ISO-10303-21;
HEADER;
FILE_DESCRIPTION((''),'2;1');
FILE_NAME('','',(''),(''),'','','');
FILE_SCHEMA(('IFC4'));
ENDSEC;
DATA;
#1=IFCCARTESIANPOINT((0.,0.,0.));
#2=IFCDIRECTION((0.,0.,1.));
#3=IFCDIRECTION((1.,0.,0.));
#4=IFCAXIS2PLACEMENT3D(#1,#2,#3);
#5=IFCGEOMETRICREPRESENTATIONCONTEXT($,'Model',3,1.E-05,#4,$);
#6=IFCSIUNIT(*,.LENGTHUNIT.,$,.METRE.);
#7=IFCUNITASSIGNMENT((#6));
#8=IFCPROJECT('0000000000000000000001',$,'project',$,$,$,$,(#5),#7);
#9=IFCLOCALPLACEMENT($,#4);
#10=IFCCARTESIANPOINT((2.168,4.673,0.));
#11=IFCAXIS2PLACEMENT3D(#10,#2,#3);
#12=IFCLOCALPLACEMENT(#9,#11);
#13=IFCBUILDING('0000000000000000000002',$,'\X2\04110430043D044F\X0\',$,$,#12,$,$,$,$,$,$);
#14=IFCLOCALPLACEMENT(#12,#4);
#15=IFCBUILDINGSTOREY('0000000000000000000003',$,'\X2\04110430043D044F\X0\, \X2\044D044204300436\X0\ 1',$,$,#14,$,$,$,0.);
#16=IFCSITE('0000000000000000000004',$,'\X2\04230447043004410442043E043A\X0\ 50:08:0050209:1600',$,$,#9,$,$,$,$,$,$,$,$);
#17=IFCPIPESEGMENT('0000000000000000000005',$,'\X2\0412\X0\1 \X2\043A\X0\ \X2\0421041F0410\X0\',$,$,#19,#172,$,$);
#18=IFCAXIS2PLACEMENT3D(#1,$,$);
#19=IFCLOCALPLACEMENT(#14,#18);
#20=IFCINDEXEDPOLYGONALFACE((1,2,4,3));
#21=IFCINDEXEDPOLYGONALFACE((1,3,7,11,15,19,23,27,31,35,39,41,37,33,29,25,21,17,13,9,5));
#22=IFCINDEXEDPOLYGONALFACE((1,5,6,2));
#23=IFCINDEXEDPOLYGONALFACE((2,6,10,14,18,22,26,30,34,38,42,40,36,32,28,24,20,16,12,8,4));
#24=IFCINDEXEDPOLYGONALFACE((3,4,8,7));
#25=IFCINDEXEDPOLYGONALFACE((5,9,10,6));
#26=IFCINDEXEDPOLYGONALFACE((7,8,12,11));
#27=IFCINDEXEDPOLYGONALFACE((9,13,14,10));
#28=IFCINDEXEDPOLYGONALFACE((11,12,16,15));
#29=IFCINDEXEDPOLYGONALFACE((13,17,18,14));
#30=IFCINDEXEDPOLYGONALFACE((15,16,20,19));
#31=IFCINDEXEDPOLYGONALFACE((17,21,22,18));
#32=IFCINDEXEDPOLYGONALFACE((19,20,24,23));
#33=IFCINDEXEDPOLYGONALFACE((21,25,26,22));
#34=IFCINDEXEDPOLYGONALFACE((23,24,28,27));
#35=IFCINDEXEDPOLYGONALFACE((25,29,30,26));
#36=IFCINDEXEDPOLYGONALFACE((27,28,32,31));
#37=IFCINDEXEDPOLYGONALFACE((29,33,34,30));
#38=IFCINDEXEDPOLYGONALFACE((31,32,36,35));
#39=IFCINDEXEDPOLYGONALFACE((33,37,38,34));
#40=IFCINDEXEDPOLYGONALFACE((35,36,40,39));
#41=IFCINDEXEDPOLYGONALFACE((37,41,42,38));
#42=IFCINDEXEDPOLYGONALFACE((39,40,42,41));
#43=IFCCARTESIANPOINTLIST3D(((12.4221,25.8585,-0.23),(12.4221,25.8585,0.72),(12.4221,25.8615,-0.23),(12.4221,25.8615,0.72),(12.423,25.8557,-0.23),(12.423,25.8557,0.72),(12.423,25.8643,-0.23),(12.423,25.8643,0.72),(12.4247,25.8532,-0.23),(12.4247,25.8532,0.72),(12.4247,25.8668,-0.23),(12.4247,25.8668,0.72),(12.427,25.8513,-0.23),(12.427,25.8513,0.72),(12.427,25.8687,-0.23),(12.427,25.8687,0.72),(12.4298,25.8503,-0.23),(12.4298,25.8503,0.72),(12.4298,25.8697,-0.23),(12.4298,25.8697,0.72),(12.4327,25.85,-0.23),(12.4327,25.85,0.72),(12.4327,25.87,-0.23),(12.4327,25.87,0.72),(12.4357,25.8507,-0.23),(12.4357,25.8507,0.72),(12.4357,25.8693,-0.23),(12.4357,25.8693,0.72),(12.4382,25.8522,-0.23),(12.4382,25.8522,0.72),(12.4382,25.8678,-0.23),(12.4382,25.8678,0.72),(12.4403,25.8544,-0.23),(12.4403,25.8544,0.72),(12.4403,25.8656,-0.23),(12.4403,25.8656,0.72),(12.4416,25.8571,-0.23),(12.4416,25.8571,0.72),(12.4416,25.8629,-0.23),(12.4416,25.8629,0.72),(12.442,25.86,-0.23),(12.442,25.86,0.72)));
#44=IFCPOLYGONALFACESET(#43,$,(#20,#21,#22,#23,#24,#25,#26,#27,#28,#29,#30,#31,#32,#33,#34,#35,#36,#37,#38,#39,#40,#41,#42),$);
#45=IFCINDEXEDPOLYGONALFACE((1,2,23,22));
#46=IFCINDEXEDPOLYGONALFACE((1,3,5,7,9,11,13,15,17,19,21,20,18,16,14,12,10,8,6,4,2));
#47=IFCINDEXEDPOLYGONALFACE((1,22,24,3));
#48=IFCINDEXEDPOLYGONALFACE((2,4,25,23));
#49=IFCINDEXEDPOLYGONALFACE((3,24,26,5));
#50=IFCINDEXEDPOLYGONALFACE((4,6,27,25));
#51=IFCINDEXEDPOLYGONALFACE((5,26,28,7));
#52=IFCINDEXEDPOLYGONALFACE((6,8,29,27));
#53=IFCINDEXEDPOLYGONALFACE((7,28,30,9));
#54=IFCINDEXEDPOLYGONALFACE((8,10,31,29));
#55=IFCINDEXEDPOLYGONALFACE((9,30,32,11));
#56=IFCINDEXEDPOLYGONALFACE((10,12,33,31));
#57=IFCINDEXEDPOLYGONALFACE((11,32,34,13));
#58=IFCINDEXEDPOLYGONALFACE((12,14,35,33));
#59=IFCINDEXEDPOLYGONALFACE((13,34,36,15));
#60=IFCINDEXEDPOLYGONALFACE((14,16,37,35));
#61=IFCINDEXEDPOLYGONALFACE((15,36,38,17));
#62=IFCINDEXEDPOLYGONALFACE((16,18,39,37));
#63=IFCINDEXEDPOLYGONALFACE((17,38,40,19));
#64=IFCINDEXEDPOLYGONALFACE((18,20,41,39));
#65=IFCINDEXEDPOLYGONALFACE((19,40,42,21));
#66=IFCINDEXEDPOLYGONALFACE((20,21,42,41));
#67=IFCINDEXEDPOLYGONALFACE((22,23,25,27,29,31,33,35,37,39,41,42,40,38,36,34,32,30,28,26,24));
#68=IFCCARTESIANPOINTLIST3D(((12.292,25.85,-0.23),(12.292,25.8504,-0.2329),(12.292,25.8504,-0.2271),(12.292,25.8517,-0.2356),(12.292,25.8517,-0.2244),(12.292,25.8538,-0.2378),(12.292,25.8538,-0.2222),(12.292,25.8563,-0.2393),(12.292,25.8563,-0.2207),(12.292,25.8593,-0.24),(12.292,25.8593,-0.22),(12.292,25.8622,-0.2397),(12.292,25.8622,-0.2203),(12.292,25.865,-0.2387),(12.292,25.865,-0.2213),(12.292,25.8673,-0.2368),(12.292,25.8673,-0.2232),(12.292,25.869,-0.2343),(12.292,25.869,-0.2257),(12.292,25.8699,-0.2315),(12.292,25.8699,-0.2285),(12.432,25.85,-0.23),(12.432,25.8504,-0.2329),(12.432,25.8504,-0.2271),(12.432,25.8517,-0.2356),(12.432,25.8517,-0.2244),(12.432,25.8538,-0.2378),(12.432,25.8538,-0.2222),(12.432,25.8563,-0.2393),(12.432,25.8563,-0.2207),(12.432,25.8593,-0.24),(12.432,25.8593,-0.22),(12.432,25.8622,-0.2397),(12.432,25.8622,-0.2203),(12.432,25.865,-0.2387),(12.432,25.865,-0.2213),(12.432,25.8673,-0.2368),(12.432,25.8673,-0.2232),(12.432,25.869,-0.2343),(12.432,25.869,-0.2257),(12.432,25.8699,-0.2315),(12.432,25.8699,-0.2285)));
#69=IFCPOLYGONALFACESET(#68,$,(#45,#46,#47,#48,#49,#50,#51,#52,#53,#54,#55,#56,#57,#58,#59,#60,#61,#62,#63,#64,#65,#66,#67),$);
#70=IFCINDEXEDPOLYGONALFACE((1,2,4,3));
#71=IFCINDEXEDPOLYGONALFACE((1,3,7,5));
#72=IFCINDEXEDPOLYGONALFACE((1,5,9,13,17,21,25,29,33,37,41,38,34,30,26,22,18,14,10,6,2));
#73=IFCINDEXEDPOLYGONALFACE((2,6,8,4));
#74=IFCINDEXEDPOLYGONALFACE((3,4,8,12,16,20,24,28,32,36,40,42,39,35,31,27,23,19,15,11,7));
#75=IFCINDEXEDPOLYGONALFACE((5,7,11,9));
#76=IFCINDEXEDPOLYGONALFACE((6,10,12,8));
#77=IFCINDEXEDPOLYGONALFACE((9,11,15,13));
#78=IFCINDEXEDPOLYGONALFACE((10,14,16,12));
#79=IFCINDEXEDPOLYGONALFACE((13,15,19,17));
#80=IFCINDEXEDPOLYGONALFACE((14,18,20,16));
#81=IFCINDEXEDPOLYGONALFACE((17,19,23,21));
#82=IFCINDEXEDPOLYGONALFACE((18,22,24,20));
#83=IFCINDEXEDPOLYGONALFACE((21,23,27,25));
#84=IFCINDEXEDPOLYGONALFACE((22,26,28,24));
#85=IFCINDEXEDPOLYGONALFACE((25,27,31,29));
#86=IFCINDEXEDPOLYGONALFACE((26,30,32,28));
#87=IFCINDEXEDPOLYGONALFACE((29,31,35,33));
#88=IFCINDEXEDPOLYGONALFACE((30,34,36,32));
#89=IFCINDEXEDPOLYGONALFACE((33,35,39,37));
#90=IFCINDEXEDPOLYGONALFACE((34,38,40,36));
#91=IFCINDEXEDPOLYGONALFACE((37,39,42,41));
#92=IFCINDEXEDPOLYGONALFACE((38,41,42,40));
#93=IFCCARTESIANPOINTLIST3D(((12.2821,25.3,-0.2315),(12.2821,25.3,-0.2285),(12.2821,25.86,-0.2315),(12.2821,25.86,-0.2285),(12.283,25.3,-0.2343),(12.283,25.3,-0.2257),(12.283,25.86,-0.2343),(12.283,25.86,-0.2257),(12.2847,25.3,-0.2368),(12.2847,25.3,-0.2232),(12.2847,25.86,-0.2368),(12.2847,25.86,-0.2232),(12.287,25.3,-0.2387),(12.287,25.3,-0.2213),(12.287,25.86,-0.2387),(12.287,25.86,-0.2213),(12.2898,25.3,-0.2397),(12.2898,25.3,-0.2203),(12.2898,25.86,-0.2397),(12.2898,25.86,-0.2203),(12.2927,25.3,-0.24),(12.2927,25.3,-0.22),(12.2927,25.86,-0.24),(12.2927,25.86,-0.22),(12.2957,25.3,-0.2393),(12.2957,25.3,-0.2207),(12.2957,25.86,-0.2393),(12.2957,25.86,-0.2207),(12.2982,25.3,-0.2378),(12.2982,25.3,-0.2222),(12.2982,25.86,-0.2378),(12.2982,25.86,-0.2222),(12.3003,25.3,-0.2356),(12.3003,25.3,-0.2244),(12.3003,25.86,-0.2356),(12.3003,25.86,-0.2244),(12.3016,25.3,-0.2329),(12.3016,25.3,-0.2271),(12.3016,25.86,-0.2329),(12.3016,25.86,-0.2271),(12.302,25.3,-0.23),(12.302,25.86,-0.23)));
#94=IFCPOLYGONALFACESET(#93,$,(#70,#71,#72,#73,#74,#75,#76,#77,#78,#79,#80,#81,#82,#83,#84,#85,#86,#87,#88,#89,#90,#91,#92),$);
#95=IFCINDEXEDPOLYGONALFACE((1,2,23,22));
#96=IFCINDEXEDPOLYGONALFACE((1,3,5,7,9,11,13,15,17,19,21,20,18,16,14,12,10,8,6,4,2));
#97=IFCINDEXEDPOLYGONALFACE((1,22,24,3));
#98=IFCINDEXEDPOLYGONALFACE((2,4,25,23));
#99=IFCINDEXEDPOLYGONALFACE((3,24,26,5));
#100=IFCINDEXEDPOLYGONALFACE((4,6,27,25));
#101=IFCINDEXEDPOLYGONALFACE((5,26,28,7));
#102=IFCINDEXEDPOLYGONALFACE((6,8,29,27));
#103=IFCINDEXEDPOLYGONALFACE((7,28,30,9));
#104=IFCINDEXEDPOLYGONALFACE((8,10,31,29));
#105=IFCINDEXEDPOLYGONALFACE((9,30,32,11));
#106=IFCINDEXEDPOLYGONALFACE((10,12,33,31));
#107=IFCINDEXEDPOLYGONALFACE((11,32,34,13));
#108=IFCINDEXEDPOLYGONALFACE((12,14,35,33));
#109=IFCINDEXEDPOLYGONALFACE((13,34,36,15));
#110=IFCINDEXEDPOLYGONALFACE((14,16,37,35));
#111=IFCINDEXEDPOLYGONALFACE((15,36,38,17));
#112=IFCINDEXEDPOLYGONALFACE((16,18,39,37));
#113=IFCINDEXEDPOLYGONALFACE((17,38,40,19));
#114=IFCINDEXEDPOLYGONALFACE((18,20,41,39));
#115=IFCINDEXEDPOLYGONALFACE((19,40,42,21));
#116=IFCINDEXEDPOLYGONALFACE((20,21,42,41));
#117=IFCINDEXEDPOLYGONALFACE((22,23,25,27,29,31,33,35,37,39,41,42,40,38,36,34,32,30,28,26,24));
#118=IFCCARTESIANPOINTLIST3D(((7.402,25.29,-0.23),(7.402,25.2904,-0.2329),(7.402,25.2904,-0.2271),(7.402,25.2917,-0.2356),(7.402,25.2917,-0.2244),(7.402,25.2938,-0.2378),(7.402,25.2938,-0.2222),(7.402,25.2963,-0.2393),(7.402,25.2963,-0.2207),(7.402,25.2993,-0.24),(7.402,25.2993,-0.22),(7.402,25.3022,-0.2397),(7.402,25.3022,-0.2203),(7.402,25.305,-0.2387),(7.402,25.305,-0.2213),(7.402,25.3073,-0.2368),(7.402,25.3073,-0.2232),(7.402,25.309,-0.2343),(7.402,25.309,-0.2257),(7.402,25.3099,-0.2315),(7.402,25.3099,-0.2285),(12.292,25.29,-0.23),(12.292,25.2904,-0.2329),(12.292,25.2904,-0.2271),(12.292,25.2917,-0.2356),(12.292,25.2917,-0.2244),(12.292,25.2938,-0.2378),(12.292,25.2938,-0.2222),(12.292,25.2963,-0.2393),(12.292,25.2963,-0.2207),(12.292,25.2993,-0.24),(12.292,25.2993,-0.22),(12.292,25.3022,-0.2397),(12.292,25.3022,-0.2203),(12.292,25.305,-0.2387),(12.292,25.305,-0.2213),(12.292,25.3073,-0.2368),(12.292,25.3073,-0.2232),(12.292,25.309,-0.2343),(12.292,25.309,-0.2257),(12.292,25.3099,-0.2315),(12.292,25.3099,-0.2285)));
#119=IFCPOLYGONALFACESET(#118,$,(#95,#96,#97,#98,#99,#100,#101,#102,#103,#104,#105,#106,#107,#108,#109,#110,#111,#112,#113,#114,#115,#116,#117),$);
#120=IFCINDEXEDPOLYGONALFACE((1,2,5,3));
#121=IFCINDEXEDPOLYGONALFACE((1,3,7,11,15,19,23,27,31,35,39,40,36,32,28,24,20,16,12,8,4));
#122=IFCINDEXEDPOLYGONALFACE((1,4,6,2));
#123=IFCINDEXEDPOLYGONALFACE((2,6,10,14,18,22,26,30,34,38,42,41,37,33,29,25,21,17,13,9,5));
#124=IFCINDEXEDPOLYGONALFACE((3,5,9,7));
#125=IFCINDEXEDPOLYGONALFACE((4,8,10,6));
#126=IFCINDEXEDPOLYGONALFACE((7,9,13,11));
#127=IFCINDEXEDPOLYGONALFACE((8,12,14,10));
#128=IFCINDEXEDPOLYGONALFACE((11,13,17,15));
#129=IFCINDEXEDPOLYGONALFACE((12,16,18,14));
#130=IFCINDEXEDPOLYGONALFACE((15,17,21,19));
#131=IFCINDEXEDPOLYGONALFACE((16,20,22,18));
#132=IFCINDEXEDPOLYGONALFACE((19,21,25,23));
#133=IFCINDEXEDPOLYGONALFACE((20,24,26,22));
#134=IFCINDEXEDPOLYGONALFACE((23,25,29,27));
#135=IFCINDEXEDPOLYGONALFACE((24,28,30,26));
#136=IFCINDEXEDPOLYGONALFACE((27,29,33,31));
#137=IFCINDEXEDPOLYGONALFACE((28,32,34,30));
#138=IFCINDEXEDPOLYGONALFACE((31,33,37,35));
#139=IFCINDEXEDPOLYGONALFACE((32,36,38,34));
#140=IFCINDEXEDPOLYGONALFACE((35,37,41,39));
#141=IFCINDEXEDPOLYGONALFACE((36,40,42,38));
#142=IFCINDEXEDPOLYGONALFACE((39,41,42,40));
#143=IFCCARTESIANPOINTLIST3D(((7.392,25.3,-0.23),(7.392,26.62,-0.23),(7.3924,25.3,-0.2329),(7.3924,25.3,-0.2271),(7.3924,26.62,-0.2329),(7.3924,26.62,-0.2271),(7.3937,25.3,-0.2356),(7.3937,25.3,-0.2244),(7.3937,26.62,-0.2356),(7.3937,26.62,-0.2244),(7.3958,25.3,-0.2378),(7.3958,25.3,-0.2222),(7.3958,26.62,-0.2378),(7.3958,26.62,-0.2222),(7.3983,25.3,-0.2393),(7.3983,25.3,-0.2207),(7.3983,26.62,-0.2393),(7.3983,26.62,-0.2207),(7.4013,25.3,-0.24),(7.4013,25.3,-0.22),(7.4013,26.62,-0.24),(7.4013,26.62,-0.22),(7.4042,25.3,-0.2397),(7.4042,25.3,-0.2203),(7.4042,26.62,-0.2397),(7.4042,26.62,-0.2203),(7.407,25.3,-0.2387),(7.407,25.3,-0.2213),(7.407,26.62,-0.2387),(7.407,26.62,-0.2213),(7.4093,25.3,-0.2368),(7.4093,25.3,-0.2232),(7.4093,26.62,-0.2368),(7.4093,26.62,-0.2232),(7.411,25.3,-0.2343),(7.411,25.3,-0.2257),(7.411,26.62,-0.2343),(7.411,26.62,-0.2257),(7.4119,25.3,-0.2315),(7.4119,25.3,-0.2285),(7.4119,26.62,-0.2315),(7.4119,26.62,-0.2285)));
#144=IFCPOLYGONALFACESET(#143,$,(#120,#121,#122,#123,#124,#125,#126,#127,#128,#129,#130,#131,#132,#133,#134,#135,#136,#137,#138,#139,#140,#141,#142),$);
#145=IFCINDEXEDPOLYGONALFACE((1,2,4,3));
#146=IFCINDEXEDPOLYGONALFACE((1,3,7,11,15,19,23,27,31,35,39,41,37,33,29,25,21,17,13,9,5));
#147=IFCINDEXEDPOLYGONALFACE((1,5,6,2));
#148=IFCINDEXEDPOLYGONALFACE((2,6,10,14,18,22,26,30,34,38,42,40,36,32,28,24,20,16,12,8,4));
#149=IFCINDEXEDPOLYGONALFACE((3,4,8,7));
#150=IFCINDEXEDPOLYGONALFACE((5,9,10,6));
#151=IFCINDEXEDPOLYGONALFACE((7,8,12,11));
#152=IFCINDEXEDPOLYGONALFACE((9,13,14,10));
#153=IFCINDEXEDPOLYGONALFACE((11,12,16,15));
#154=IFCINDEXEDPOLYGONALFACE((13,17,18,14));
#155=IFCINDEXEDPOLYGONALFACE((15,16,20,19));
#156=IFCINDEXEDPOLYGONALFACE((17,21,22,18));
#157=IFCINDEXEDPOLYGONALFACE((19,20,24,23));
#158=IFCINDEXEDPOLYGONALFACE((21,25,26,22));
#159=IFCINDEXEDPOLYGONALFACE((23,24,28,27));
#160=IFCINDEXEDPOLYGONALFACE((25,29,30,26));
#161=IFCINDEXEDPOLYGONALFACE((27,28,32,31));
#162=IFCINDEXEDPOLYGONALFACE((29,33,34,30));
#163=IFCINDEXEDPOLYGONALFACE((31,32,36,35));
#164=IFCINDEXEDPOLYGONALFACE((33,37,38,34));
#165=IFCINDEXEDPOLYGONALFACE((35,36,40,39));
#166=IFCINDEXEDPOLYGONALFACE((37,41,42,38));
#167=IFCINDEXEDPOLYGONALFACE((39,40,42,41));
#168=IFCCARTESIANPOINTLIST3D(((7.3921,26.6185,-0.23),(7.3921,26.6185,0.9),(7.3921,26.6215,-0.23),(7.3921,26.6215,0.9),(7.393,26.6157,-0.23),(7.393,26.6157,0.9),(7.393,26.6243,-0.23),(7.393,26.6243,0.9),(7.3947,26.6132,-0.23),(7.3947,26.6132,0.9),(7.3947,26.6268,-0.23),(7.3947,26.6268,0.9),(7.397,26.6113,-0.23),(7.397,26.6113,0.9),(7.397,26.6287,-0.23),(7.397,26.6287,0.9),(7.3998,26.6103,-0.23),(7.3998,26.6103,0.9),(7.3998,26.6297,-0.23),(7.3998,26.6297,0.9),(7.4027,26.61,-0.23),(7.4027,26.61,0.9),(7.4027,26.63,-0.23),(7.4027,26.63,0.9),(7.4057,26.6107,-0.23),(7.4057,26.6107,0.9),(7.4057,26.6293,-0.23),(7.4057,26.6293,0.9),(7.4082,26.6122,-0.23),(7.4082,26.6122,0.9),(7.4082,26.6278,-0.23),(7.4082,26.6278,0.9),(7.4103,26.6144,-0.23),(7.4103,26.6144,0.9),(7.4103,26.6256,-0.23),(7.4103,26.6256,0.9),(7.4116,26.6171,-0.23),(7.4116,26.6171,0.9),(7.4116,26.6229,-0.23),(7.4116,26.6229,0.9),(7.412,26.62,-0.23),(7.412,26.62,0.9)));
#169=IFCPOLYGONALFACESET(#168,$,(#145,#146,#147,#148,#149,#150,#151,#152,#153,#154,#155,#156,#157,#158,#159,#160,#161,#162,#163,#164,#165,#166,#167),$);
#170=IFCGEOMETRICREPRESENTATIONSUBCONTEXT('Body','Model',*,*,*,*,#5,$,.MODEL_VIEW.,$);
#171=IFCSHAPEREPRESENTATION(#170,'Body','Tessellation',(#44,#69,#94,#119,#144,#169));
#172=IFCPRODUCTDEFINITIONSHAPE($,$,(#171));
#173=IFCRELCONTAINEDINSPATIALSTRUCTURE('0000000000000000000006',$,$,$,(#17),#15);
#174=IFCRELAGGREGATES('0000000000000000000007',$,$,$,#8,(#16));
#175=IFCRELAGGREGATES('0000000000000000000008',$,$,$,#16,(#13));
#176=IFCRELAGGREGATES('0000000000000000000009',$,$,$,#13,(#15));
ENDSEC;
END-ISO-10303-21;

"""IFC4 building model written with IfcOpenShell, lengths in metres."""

from ifc_helpers import new_model, si_unit, frame, origin_with_axes, origin_2d, place, context, subcontext, project, spatial, circle, extrude, element, save


model = new_model("IFC4")

# Units and contexts
model_context = context("Model", 3, precision=1e-05, world=origin_with_axes())
body_context = subcontext(model_context, "Body", "Model", "MODEL_VIEW")
ifc_project = project(units=[si_unit("LENGTHUNIT", "METRE")], contexts=[model_context])

# Site, building, storey
site_placement = place(None, origin_with_axes())
site = spatial("IfcSite", under=ifc_project, at=site_placement, Name="Участок 50:08:0050209:1600")
building_placement = place(site_placement, frame((2.168, 4.673, 0.0), z_axis=(0.0, 0.0, 1.0), x_axis=(1.0, 0.0, 0.0)))
building = spatial("IfcBuilding", under=site, at=building_placement, Name="Баня")
storey_placement = place(building_placement, origin_with_axes())
storey = spatial("IfcBuildingStorey", under=building, at=storey_placement, Name="Баня, этаж 1", Elevation=0.0)

# Pipe segment
pipe_segment_1_placement = place(storey_placement, origin_with_axes())
element("IfcPipeSegment", 1, at=pipe_segment_1_placement, inside=storey, Name="В1 к СПА", context=body_context, shape_type="SweptSolid", body=[
    extrude(circle(Radius=0.01, at=origin_2d()), frame((12.432, 25.86, 0.72), z_axis=(0.0, 0.0, -1.0), x_axis=(1.0, 0.0, 0.0)), (0.0, 0.0, 1.0), 0.95),
    extrude(circle(Radius=0.01, at=origin_2d()), frame((12.432, 25.86, -0.23), z_axis=(-1.0, 0.0, 0.0), x_axis=(0.0, -1.0, 0.0)), (0.0, 0.0, 1.0), 0.14),
    extrude(circle(Radius=0.01, at=origin_2d()), frame((12.292, 25.86, -0.23), z_axis=(0.0, -1.0, 0.0), x_axis=(1.0, 0.0, 0.0)), (0.0, 0.0, 1.0), 0.56),
    extrude(circle(Radius=0.01, at=origin_2d()), frame((12.292, 25.3, -0.23), z_axis=(-1.0, 0.0, 0.0), x_axis=(0.0, -1.0, 0.0)), (0.0, 0.0, 1.0), 4.89),
    extrude(circle(Radius=0.01, at=origin_2d()), frame((7.402, 25.3, -0.23), z_axis=(0.0, 1.0, 0.0), x_axis=(-1.0, 0.0, 0.0)), (0.0, 0.0, 1.0), 1.32),
    extrude(circle(Radius=0.01, at=origin_2d()), frame((7.402, 26.62, -0.23), z_axis=(0.0, 0.0, 1.0), x_axis=(1.0, 0.0, 0.0)), (0.0, 0.0, 1.0), 1.13),
])

save(model, "model.ifc")
